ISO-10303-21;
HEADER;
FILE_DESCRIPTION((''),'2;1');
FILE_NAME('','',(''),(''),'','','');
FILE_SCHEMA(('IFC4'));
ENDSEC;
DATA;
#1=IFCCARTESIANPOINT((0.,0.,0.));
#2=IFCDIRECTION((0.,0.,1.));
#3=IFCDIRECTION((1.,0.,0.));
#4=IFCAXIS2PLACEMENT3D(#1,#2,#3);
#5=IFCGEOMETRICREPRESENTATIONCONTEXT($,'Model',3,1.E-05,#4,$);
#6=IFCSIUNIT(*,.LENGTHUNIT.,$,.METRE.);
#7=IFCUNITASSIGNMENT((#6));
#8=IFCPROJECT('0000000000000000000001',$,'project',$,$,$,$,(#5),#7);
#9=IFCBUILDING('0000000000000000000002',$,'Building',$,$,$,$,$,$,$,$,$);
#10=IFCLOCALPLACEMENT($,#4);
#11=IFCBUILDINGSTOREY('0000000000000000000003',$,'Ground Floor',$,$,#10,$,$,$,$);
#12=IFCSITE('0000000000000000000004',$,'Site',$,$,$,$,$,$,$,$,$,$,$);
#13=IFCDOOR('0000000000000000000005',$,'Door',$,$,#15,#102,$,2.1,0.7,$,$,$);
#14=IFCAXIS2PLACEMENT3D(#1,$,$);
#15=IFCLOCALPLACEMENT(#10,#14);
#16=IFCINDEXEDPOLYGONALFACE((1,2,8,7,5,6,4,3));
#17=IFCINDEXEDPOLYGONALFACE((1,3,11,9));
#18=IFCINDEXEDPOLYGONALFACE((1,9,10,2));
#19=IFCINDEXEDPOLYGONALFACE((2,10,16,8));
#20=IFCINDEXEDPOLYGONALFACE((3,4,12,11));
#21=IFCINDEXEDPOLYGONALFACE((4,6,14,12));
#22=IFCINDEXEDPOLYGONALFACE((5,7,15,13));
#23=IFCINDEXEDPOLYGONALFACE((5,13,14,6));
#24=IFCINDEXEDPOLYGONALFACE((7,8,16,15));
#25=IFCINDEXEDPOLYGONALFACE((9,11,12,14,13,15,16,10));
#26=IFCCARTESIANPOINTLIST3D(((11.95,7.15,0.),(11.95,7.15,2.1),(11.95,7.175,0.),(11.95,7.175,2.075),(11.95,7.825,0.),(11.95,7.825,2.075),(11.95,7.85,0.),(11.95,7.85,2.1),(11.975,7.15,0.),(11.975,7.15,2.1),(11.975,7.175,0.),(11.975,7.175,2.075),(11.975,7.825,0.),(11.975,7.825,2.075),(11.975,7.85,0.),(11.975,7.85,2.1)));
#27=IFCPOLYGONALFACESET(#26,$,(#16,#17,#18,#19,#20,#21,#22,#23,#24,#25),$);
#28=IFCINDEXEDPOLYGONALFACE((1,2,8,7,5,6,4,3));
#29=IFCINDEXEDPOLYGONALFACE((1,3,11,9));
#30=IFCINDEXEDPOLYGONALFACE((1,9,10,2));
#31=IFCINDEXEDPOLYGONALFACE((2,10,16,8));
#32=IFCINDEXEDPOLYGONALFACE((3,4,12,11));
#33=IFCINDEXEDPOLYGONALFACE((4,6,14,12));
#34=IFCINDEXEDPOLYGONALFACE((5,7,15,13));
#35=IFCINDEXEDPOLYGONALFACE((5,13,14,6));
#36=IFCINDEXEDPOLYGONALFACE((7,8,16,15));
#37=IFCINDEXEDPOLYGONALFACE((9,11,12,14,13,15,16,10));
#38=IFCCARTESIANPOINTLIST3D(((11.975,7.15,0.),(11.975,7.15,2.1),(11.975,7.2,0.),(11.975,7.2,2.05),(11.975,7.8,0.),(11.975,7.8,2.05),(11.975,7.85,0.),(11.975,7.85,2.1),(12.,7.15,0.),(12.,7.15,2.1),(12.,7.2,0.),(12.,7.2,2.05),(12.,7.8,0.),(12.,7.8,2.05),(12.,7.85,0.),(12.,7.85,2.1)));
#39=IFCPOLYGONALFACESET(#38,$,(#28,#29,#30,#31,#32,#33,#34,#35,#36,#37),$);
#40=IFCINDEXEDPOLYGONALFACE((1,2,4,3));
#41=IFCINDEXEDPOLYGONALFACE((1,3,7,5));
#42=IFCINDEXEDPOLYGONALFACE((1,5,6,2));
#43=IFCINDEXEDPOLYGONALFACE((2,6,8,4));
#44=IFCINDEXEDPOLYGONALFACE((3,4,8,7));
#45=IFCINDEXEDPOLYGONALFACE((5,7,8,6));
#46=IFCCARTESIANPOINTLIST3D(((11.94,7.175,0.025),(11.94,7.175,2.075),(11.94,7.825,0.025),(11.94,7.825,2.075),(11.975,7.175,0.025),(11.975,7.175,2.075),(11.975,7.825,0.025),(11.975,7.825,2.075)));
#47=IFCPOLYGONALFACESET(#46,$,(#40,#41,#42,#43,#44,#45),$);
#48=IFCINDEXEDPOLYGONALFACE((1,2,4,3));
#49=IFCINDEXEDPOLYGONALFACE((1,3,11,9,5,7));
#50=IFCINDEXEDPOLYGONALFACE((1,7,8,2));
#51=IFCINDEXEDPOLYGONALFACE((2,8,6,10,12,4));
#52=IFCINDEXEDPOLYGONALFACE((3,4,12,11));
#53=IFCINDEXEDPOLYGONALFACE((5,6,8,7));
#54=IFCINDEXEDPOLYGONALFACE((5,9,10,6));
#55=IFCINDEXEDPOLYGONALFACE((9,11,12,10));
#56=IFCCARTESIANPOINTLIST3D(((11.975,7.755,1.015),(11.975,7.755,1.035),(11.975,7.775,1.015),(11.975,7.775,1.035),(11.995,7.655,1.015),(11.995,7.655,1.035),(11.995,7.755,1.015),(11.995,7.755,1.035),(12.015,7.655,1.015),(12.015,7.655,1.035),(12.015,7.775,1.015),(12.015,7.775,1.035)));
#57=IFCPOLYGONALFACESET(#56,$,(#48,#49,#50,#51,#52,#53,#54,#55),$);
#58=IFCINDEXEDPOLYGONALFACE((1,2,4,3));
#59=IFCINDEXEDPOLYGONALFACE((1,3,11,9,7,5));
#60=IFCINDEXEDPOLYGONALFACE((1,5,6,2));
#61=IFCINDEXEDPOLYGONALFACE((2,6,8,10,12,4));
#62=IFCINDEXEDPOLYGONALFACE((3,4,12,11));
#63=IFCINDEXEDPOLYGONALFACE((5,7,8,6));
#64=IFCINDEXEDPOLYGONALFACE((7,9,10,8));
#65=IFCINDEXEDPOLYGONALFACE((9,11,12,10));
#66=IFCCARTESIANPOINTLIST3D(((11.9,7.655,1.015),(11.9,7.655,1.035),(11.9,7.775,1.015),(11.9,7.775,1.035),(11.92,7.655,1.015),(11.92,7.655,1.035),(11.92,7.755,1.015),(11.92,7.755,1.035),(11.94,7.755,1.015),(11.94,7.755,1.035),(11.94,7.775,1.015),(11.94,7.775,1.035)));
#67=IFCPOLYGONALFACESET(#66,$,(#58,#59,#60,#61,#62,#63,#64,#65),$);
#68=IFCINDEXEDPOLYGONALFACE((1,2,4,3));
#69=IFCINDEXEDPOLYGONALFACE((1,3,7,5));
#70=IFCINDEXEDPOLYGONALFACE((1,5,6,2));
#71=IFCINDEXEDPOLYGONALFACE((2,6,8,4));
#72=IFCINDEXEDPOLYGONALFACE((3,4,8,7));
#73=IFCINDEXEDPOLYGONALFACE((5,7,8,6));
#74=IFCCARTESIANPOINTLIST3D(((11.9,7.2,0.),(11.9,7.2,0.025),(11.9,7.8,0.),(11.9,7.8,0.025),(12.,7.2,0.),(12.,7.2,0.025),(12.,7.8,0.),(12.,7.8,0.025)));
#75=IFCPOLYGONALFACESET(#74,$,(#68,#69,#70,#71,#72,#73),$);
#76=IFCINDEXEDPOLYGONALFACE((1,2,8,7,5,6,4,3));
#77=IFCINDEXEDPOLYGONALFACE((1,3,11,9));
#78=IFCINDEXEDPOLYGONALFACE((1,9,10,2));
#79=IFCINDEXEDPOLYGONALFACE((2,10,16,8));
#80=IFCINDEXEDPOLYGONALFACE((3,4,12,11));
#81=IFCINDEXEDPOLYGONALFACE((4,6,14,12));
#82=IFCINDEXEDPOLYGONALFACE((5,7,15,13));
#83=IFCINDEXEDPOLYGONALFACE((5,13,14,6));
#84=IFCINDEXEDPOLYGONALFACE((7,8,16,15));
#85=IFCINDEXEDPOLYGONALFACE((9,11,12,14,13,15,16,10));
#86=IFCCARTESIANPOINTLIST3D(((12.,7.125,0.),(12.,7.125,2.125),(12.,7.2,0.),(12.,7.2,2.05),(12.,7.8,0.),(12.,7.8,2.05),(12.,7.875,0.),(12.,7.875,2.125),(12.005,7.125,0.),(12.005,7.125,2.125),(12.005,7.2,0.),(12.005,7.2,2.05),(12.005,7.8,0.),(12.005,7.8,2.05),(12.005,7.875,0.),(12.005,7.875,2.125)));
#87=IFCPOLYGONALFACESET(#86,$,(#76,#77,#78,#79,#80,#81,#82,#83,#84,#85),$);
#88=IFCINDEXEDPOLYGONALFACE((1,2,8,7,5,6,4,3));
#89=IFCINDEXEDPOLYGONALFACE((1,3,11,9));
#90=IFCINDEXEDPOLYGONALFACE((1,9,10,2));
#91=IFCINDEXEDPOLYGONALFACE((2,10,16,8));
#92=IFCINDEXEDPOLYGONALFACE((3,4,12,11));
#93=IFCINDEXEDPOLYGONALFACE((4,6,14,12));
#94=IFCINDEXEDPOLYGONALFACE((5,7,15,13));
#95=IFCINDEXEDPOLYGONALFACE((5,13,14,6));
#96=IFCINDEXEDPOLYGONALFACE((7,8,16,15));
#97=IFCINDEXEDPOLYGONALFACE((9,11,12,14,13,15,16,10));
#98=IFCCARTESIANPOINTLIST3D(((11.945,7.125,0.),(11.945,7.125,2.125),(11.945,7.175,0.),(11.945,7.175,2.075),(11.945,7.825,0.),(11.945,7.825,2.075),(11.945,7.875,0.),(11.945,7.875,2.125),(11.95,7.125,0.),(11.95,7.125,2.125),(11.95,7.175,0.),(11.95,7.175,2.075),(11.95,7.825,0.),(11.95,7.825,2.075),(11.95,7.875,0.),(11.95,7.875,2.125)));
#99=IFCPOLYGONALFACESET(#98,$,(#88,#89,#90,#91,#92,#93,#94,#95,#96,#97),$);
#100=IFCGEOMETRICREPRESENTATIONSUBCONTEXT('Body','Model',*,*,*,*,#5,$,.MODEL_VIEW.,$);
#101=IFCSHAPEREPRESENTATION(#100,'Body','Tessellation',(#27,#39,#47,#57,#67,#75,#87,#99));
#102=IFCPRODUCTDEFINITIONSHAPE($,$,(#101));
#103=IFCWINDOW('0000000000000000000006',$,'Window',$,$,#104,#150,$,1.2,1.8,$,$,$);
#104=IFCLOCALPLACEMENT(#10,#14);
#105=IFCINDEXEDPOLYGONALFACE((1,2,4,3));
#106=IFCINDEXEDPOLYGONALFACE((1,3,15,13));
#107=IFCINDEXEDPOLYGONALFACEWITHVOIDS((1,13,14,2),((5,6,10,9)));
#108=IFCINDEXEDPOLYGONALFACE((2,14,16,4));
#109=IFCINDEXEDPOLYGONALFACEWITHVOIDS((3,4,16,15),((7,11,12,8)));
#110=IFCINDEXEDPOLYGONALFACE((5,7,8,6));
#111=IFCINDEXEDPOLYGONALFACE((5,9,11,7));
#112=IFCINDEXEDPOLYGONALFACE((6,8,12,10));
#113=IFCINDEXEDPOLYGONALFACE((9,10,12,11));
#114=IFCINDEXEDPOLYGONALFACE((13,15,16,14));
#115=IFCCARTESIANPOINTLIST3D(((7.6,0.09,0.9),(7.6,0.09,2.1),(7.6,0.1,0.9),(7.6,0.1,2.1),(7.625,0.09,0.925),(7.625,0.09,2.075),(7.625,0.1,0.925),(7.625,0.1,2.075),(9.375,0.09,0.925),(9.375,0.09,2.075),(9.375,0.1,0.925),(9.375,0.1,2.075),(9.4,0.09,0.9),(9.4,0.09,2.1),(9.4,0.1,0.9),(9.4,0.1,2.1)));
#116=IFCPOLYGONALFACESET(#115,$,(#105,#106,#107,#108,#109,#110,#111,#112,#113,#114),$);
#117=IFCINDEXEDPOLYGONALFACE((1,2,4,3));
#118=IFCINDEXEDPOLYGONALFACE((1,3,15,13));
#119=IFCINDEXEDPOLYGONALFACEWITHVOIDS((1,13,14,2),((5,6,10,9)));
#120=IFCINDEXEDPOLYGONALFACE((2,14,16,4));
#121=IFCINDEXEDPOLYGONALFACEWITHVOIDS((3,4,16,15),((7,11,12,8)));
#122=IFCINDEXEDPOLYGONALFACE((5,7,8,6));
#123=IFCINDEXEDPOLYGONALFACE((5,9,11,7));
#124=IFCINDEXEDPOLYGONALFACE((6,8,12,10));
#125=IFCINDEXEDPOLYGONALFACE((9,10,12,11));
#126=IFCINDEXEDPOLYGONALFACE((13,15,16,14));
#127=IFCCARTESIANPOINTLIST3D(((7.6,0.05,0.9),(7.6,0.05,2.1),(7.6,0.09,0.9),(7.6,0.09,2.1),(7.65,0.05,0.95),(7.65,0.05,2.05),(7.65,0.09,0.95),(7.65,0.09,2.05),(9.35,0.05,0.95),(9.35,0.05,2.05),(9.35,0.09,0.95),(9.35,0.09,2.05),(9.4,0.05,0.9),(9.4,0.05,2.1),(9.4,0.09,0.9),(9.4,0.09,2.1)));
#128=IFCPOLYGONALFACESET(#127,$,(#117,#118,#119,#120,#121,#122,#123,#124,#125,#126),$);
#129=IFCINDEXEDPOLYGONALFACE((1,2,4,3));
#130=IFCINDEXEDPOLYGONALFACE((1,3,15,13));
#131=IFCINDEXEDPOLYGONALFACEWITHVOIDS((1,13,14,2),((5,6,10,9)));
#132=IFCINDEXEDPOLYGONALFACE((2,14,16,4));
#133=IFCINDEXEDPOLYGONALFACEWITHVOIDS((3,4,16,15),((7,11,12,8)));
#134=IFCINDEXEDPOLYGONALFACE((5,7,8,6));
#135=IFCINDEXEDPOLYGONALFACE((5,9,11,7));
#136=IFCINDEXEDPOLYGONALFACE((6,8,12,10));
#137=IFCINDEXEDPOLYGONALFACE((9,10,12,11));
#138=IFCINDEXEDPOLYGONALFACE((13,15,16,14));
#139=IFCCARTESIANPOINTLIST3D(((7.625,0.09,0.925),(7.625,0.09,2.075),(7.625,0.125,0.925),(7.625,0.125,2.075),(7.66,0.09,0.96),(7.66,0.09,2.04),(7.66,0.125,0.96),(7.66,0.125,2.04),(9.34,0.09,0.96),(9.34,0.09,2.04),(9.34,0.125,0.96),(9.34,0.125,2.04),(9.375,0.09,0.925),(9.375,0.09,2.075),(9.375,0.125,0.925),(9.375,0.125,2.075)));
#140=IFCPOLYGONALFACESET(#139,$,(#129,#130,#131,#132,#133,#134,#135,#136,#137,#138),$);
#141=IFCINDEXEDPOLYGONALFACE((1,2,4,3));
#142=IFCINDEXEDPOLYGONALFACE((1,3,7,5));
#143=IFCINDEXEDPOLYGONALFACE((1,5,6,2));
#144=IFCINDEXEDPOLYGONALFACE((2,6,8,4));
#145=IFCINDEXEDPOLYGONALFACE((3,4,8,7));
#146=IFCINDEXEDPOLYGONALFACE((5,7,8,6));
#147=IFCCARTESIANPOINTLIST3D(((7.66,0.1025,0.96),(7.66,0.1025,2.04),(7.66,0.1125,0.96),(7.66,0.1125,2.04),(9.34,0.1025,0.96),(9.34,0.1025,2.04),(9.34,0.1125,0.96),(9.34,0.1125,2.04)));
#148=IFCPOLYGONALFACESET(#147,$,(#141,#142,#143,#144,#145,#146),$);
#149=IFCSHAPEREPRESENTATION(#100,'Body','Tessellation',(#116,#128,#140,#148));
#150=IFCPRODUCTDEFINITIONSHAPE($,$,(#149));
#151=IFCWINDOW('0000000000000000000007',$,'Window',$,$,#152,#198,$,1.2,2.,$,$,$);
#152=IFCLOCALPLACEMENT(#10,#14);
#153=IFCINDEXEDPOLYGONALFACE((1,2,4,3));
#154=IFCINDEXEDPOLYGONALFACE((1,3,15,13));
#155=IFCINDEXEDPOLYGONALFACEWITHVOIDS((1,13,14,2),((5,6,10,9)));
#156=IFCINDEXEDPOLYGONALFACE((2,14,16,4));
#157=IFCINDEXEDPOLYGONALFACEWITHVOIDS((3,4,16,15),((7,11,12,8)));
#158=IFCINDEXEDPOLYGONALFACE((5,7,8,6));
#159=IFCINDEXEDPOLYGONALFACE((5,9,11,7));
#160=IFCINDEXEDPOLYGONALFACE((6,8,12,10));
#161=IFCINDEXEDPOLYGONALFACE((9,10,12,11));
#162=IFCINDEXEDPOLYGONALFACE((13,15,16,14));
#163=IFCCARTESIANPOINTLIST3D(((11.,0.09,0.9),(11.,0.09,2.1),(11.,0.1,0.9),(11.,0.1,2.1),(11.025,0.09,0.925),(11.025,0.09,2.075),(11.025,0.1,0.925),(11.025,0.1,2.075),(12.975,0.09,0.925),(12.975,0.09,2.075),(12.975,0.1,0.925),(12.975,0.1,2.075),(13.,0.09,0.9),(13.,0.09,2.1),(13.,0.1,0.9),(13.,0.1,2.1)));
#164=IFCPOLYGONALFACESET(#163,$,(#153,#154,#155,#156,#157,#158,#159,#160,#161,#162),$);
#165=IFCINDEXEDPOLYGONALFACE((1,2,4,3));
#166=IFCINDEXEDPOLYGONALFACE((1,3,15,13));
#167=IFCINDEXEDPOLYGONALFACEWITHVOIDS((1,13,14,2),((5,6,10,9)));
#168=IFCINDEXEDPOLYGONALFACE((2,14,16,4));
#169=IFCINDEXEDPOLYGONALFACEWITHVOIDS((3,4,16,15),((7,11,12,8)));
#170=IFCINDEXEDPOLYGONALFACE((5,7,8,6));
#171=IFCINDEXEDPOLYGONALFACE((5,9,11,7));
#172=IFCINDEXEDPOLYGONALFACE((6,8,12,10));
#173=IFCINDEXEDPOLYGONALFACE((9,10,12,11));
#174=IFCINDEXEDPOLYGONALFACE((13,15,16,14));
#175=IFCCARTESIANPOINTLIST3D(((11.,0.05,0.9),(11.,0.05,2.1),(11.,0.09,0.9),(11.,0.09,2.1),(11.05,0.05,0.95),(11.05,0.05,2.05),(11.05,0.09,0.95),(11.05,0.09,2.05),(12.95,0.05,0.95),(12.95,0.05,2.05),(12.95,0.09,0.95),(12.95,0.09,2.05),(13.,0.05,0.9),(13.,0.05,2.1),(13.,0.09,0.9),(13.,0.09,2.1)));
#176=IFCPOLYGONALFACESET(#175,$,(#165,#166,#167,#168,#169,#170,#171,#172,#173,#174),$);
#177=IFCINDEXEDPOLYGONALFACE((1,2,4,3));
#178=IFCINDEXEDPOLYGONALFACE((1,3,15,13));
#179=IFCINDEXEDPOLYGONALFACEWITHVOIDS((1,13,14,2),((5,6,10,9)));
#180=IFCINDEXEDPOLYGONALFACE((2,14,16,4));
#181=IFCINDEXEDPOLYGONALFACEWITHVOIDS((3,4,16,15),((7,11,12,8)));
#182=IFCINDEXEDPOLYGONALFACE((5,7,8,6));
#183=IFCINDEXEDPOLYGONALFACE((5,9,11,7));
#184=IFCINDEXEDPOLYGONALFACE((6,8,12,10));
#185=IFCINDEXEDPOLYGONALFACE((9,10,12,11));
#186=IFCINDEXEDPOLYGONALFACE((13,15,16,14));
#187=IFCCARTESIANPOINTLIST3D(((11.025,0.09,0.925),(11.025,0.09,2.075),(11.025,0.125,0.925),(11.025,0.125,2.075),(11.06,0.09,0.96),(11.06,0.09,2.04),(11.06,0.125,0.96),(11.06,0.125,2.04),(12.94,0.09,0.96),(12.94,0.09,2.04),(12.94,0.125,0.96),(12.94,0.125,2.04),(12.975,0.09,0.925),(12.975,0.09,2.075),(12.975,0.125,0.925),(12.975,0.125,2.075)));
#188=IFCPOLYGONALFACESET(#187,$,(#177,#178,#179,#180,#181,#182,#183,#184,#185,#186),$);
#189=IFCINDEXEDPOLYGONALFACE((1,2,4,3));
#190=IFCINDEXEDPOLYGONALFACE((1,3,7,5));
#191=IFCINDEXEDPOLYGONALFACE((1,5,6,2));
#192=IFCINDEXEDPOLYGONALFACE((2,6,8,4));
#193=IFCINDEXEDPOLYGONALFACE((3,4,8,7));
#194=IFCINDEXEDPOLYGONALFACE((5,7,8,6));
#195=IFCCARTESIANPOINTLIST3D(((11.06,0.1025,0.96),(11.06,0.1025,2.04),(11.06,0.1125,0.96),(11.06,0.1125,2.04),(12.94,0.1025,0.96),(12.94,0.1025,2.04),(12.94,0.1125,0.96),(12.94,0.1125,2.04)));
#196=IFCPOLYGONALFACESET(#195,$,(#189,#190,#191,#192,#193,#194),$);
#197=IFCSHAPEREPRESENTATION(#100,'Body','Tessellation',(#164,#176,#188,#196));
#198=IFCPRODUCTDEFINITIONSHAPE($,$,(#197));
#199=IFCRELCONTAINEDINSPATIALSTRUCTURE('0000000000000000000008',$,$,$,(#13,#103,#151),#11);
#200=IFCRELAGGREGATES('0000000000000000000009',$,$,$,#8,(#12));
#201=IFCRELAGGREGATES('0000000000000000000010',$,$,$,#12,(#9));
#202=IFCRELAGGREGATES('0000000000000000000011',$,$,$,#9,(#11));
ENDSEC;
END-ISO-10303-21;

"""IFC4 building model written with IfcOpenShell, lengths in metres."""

from ifc_helpers import new_model, si_unit, frame, origin_with_axes, place, context, subcontext, project, spatial, line, indexed_curve, outline, extrude, element, save


model = new_model("IFC4")

# Units and contexts
model_context = context("Model", 3, precision=1e-05, world=origin_with_axes())
body_context = subcontext(model_context, "Body", "Model", "MODEL_VIEW")
ifc_project = project(units=[si_unit("LENGTHUNIT", "METRE")], contexts=[model_context])

# Site, building, storey
site = spatial("IfcSite", under=ifc_project, Name="Site")
building = spatial("IfcBuilding", under=site, Name="Building")
storey_placement = place(None, origin_with_axes())
storey = spatial("IfcBuildingStorey", under=building, at=storey_placement, Name="Ground Floor")

# Door
door_1_placement = place(storey_placement, frame((12.0, 7.15, 0.0), z_axis=(0.0, 0.0, 1.0), x_axis=(0.0, 1.0, 0.0)))
element("IfcDoor", 1, at=door_1_placement, inside=storey, Name="Door", OverallHeight=2.1, OverallWidth=0.7, context=body_context, shape_type="SweptSolid", body=[
    extrude(outline(indexed_curve([(0.0, 0.0), (0.0, 2.1), (0.7, 2.1), (0.7, 0.0), (0.675, 0.0), (0.675, 2.075), (0.025, 2.075), (0.025, 0.0)], segments=[line(1, 2, 3, 4, 5, 6, 7, 8, 1)])), frame((0.0, 0.025, 0.0), z_axis=(0.0, -1.0, 0.0), x_axis=(1.0, 0.0, 0.0)), (0.0, 0.0, -1.0), 0.025),
    extrude(outline(indexed_curve([(0.0, 0.0), (0.0, 2.1), (0.7, 2.1), (0.7, 0.0), (0.65, 0.0), (0.65, 2.05), (0.05, 2.05), (0.05, 0.0)], segments=[line(1, 2, 3, 4, 5, 6, 7, 8, 1)])), frame((0.0, 0.0, 0.0), z_axis=(0.0, -1.0, 0.0), x_axis=(1.0, 0.0, 0.0)), (0.0, 0.0, -1.0), 0.025),
    extrude(outline(indexed_curve([(0.0, 0.0), (0.65, 0.0), (0.65, 0.035), (0.0, 0.035)], segments=[line(1, 2, 3, 4, 1)])), frame((0.025, 0.025, 0.025), z_axis=(0.0, 0.0, 1.0), x_axis=(1.0, 0.0, 0.0)), (0.0, 0.0, 1.0), 2.05),
    extrude(outline(indexed_curve([(0.0, 0.0), (0.0, -0.04), (-0.12, -0.04), (-0.12, -0.02), (-0.02, -0.02), (-0.02, 0.0)], segments=[line(1, 2, 3, 4, 5, 6, 1)])), frame((0.625, 0.025, 1.015), z_axis=(0.0, 0.0, 1.0), x_axis=(1.0, 0.0, 0.0)), (0.0, 0.0, 1.0), 0.02),
    extrude(outline(indexed_curve([(0.0, 0.0), (0.0, 0.04), (-0.12, 0.04), (-0.12, 0.02), (-0.02, 0.02), (-0.02, 0.0)], segments=[line(1, 2, 3, 4, 5, 6, 1)])), frame((0.625, 0.06, 1.015), z_axis=(0.0, 0.0, 1.0), x_axis=(1.0, 0.0, 0.0)), (0.0, 0.0, 1.0), 0.02),
    extrude(outline(indexed_curve([(0.0, 0.0), (0.6, 0.0), (0.6, 0.1), (0.0, 0.1)], segments=[line(1, 2, 3, 4, 1)])), frame((0.05, 0.0, 0.0), z_axis=(0.0, 0.0, 1.0), x_axis=(1.0, 0.0, 0.0)), (0.0, 0.0, 1.0), 0.025),
    extrude(outline(indexed_curve([(0.0, 0.0), (0.0, 2.125), (0.75, 2.125), (0.75, 0.0), (0.675, 0.0), (0.675, 2.05), (0.075, 2.05), (0.075, 0.0)], segments=[line(1, 2, 3, 4, 5, 6, 7, 8, 1)])), frame((-0.025, -0.005, 0.0), z_axis=(0.0, -1.0, 0.0), x_axis=(1.0, 0.0, 0.0)), (0.0, 0.0, -1.0), 0.005),
    extrude(outline(indexed_curve([(0.0, 0.0), (0.0, 2.125), (0.75, 2.125), (0.75, 0.0), (0.7, 0.0), (0.7, 2.075), (0.05, 2.075), (0.05, 0.0)], segments=[line(1, 2, 3, 4, 5, 6, 7, 8, 1)])), frame((-0.025, 0.05, 0.0), z_axis=(0.0, -1.0, 0.0), x_axis=(1.0, 0.0, 0.0)), (0.0, 0.0, -1.0), 0.005),
])

# Windows
window_1_placement = place(storey_placement, frame((7.6, 0.0, 0.9), z_axis=(0.0, 0.0, 1.0), x_axis=(1.0, 0.0, 0.0)))
element("IfcWindow", 2, at=window_1_placement, inside=storey, Name="Window", OverallHeight=1.2, OverallWidth=1.8, context=body_context, shape_type="SweptSolid", body=[
    extrude(outline(indexed_curve([(0.0, 0.0), (1.8, 0.0), (1.8, 1.2), (0.0, 1.2)], segments=[line(1, 2, 3, 4, 1)]), holes=[indexed_curve([(0.025, 0.025), (1.775, 0.025), (1.775, 1.175), (0.025, 1.175)], segments=[line(1, 2, 3, 4, 1)])]), frame((0.0, 0.09, 0.0), z_axis=(0.0, -1.0, 0.0), x_axis=(1.0, 0.0, 0.0)), (0.0, 0.0, -1.0), 0.01),
    extrude(outline(indexed_curve([(0.0, 0.0), (1.8, 0.0), (1.8, 1.2), (0.0, 1.2)], segments=[line(1, 2, 3, 4, 1)]), holes=[indexed_curve([(0.05, 0.05), (1.75, 0.05), (1.75, 1.15), (0.05, 1.15)], segments=[line(1, 2, 3, 4, 1)])]), frame((0.0, 0.05, 0.0), z_axis=(0.0, -1.0, 0.0), x_axis=(1.0, 0.0, 0.0)), (0.0, 0.0, -1.0), 0.04),
    extrude(outline(indexed_curve([(0.0, 0.0), (1.75, 0.0), (1.75, 1.15), (0.0, 1.15)], segments=[line(1, 2, 3, 4, 1)]), holes=[indexed_curve([(0.035, 0.035), (1.715, 0.035), (1.715, 1.115), (0.035, 1.115)], segments=[line(1, 2, 3, 4, 1)])]), frame((0.025, 0.09, 0.025), z_axis=(0.0, -1.0, 0.0), x_axis=(1.0, 0.0, 0.0)), (0.0, 0.0, -1.0), 0.035),
    extrude(outline(indexed_curve([(0.035, 0.035), (1.715, 0.035), (1.715, 1.115), (0.035, 1.115)], segments=[line(1, 2, 3, 4, 1)])), frame((0.025, 0.1025, 0.025), z_axis=(0.0, -1.0, 0.0), x_axis=(1.0, 0.0, 0.0)), (0.0, 0.0, -1.0), 0.01),
])
window_2_placement = place(storey_placement, frame((11.0, 0.0, 0.9), z_axis=(0.0, 0.0, 1.0), x_axis=(1.0, 0.0, 0.0)))
element("IfcWindow", 3, at=window_2_placement, inside=storey, Name="Window", OverallHeight=1.2, OverallWidth=2.0, context=body_context, shape_type="SweptSolid", body=[
    extrude(outline(indexed_curve([(0.0, 0.0), (2.0, 0.0), (2.0, 1.2), (0.0, 1.2)], segments=[line(1, 2, 3, 4, 1)]), holes=[indexed_curve([(0.025, 0.025), (1.975, 0.025), (1.975, 1.175), (0.025, 1.175)], segments=[line(1, 2, 3, 4, 1)])]), frame((0.0, 0.09, 0.0), z_axis=(0.0, -1.0, 0.0), x_axis=(1.0, 0.0, 0.0)), (0.0, 0.0, -1.0), 0.01),
    extrude(outline(indexed_curve([(0.0, 0.0), (2.0, 0.0), (2.0, 1.2), (0.0, 1.2)], segments=[line(1, 2, 3, 4, 1)]), holes=[indexed_curve([(0.05, 0.05), (1.95, 0.05), (1.95, 1.15), (0.05, 1.15)], segments=[line(1, 2, 3, 4, 1)])]), frame((0.0, 0.05, 0.0), z_axis=(0.0, -1.0, 0.0), x_axis=(1.0, 0.0, 0.0)), (0.0, 0.0, -1.0), 0.04),
    extrude(outline(indexed_curve([(0.0, 0.0), (1.95, 0.0), (1.95, 1.15), (0.0, 1.15)], segments=[line(1, 2, 3, 4, 1)]), holes=[indexed_curve([(0.035, 0.035), (1.915, 0.035), (1.915, 1.115), (0.035, 1.115)], segments=[line(1, 2, 3, 4, 1)])]), frame((0.025, 0.09, 0.025), z_axis=(0.0, -1.0, 0.0), x_axis=(1.0, 0.0, 0.0)), (0.0, 0.0, -1.0), 0.035),
    extrude(outline(indexed_curve([(0.035, 0.035), (1.915, 0.035), (1.915, 1.115), (0.035, 1.115)], segments=[line(1, 2, 3, 4, 1)])), frame((0.025, 0.1025, 0.025), z_axis=(0.0, -1.0, 0.0), x_axis=(1.0, 0.0, 0.0)), (0.0, 0.0, -1.0), 0.01),
])

save(model, "model.ifc")
